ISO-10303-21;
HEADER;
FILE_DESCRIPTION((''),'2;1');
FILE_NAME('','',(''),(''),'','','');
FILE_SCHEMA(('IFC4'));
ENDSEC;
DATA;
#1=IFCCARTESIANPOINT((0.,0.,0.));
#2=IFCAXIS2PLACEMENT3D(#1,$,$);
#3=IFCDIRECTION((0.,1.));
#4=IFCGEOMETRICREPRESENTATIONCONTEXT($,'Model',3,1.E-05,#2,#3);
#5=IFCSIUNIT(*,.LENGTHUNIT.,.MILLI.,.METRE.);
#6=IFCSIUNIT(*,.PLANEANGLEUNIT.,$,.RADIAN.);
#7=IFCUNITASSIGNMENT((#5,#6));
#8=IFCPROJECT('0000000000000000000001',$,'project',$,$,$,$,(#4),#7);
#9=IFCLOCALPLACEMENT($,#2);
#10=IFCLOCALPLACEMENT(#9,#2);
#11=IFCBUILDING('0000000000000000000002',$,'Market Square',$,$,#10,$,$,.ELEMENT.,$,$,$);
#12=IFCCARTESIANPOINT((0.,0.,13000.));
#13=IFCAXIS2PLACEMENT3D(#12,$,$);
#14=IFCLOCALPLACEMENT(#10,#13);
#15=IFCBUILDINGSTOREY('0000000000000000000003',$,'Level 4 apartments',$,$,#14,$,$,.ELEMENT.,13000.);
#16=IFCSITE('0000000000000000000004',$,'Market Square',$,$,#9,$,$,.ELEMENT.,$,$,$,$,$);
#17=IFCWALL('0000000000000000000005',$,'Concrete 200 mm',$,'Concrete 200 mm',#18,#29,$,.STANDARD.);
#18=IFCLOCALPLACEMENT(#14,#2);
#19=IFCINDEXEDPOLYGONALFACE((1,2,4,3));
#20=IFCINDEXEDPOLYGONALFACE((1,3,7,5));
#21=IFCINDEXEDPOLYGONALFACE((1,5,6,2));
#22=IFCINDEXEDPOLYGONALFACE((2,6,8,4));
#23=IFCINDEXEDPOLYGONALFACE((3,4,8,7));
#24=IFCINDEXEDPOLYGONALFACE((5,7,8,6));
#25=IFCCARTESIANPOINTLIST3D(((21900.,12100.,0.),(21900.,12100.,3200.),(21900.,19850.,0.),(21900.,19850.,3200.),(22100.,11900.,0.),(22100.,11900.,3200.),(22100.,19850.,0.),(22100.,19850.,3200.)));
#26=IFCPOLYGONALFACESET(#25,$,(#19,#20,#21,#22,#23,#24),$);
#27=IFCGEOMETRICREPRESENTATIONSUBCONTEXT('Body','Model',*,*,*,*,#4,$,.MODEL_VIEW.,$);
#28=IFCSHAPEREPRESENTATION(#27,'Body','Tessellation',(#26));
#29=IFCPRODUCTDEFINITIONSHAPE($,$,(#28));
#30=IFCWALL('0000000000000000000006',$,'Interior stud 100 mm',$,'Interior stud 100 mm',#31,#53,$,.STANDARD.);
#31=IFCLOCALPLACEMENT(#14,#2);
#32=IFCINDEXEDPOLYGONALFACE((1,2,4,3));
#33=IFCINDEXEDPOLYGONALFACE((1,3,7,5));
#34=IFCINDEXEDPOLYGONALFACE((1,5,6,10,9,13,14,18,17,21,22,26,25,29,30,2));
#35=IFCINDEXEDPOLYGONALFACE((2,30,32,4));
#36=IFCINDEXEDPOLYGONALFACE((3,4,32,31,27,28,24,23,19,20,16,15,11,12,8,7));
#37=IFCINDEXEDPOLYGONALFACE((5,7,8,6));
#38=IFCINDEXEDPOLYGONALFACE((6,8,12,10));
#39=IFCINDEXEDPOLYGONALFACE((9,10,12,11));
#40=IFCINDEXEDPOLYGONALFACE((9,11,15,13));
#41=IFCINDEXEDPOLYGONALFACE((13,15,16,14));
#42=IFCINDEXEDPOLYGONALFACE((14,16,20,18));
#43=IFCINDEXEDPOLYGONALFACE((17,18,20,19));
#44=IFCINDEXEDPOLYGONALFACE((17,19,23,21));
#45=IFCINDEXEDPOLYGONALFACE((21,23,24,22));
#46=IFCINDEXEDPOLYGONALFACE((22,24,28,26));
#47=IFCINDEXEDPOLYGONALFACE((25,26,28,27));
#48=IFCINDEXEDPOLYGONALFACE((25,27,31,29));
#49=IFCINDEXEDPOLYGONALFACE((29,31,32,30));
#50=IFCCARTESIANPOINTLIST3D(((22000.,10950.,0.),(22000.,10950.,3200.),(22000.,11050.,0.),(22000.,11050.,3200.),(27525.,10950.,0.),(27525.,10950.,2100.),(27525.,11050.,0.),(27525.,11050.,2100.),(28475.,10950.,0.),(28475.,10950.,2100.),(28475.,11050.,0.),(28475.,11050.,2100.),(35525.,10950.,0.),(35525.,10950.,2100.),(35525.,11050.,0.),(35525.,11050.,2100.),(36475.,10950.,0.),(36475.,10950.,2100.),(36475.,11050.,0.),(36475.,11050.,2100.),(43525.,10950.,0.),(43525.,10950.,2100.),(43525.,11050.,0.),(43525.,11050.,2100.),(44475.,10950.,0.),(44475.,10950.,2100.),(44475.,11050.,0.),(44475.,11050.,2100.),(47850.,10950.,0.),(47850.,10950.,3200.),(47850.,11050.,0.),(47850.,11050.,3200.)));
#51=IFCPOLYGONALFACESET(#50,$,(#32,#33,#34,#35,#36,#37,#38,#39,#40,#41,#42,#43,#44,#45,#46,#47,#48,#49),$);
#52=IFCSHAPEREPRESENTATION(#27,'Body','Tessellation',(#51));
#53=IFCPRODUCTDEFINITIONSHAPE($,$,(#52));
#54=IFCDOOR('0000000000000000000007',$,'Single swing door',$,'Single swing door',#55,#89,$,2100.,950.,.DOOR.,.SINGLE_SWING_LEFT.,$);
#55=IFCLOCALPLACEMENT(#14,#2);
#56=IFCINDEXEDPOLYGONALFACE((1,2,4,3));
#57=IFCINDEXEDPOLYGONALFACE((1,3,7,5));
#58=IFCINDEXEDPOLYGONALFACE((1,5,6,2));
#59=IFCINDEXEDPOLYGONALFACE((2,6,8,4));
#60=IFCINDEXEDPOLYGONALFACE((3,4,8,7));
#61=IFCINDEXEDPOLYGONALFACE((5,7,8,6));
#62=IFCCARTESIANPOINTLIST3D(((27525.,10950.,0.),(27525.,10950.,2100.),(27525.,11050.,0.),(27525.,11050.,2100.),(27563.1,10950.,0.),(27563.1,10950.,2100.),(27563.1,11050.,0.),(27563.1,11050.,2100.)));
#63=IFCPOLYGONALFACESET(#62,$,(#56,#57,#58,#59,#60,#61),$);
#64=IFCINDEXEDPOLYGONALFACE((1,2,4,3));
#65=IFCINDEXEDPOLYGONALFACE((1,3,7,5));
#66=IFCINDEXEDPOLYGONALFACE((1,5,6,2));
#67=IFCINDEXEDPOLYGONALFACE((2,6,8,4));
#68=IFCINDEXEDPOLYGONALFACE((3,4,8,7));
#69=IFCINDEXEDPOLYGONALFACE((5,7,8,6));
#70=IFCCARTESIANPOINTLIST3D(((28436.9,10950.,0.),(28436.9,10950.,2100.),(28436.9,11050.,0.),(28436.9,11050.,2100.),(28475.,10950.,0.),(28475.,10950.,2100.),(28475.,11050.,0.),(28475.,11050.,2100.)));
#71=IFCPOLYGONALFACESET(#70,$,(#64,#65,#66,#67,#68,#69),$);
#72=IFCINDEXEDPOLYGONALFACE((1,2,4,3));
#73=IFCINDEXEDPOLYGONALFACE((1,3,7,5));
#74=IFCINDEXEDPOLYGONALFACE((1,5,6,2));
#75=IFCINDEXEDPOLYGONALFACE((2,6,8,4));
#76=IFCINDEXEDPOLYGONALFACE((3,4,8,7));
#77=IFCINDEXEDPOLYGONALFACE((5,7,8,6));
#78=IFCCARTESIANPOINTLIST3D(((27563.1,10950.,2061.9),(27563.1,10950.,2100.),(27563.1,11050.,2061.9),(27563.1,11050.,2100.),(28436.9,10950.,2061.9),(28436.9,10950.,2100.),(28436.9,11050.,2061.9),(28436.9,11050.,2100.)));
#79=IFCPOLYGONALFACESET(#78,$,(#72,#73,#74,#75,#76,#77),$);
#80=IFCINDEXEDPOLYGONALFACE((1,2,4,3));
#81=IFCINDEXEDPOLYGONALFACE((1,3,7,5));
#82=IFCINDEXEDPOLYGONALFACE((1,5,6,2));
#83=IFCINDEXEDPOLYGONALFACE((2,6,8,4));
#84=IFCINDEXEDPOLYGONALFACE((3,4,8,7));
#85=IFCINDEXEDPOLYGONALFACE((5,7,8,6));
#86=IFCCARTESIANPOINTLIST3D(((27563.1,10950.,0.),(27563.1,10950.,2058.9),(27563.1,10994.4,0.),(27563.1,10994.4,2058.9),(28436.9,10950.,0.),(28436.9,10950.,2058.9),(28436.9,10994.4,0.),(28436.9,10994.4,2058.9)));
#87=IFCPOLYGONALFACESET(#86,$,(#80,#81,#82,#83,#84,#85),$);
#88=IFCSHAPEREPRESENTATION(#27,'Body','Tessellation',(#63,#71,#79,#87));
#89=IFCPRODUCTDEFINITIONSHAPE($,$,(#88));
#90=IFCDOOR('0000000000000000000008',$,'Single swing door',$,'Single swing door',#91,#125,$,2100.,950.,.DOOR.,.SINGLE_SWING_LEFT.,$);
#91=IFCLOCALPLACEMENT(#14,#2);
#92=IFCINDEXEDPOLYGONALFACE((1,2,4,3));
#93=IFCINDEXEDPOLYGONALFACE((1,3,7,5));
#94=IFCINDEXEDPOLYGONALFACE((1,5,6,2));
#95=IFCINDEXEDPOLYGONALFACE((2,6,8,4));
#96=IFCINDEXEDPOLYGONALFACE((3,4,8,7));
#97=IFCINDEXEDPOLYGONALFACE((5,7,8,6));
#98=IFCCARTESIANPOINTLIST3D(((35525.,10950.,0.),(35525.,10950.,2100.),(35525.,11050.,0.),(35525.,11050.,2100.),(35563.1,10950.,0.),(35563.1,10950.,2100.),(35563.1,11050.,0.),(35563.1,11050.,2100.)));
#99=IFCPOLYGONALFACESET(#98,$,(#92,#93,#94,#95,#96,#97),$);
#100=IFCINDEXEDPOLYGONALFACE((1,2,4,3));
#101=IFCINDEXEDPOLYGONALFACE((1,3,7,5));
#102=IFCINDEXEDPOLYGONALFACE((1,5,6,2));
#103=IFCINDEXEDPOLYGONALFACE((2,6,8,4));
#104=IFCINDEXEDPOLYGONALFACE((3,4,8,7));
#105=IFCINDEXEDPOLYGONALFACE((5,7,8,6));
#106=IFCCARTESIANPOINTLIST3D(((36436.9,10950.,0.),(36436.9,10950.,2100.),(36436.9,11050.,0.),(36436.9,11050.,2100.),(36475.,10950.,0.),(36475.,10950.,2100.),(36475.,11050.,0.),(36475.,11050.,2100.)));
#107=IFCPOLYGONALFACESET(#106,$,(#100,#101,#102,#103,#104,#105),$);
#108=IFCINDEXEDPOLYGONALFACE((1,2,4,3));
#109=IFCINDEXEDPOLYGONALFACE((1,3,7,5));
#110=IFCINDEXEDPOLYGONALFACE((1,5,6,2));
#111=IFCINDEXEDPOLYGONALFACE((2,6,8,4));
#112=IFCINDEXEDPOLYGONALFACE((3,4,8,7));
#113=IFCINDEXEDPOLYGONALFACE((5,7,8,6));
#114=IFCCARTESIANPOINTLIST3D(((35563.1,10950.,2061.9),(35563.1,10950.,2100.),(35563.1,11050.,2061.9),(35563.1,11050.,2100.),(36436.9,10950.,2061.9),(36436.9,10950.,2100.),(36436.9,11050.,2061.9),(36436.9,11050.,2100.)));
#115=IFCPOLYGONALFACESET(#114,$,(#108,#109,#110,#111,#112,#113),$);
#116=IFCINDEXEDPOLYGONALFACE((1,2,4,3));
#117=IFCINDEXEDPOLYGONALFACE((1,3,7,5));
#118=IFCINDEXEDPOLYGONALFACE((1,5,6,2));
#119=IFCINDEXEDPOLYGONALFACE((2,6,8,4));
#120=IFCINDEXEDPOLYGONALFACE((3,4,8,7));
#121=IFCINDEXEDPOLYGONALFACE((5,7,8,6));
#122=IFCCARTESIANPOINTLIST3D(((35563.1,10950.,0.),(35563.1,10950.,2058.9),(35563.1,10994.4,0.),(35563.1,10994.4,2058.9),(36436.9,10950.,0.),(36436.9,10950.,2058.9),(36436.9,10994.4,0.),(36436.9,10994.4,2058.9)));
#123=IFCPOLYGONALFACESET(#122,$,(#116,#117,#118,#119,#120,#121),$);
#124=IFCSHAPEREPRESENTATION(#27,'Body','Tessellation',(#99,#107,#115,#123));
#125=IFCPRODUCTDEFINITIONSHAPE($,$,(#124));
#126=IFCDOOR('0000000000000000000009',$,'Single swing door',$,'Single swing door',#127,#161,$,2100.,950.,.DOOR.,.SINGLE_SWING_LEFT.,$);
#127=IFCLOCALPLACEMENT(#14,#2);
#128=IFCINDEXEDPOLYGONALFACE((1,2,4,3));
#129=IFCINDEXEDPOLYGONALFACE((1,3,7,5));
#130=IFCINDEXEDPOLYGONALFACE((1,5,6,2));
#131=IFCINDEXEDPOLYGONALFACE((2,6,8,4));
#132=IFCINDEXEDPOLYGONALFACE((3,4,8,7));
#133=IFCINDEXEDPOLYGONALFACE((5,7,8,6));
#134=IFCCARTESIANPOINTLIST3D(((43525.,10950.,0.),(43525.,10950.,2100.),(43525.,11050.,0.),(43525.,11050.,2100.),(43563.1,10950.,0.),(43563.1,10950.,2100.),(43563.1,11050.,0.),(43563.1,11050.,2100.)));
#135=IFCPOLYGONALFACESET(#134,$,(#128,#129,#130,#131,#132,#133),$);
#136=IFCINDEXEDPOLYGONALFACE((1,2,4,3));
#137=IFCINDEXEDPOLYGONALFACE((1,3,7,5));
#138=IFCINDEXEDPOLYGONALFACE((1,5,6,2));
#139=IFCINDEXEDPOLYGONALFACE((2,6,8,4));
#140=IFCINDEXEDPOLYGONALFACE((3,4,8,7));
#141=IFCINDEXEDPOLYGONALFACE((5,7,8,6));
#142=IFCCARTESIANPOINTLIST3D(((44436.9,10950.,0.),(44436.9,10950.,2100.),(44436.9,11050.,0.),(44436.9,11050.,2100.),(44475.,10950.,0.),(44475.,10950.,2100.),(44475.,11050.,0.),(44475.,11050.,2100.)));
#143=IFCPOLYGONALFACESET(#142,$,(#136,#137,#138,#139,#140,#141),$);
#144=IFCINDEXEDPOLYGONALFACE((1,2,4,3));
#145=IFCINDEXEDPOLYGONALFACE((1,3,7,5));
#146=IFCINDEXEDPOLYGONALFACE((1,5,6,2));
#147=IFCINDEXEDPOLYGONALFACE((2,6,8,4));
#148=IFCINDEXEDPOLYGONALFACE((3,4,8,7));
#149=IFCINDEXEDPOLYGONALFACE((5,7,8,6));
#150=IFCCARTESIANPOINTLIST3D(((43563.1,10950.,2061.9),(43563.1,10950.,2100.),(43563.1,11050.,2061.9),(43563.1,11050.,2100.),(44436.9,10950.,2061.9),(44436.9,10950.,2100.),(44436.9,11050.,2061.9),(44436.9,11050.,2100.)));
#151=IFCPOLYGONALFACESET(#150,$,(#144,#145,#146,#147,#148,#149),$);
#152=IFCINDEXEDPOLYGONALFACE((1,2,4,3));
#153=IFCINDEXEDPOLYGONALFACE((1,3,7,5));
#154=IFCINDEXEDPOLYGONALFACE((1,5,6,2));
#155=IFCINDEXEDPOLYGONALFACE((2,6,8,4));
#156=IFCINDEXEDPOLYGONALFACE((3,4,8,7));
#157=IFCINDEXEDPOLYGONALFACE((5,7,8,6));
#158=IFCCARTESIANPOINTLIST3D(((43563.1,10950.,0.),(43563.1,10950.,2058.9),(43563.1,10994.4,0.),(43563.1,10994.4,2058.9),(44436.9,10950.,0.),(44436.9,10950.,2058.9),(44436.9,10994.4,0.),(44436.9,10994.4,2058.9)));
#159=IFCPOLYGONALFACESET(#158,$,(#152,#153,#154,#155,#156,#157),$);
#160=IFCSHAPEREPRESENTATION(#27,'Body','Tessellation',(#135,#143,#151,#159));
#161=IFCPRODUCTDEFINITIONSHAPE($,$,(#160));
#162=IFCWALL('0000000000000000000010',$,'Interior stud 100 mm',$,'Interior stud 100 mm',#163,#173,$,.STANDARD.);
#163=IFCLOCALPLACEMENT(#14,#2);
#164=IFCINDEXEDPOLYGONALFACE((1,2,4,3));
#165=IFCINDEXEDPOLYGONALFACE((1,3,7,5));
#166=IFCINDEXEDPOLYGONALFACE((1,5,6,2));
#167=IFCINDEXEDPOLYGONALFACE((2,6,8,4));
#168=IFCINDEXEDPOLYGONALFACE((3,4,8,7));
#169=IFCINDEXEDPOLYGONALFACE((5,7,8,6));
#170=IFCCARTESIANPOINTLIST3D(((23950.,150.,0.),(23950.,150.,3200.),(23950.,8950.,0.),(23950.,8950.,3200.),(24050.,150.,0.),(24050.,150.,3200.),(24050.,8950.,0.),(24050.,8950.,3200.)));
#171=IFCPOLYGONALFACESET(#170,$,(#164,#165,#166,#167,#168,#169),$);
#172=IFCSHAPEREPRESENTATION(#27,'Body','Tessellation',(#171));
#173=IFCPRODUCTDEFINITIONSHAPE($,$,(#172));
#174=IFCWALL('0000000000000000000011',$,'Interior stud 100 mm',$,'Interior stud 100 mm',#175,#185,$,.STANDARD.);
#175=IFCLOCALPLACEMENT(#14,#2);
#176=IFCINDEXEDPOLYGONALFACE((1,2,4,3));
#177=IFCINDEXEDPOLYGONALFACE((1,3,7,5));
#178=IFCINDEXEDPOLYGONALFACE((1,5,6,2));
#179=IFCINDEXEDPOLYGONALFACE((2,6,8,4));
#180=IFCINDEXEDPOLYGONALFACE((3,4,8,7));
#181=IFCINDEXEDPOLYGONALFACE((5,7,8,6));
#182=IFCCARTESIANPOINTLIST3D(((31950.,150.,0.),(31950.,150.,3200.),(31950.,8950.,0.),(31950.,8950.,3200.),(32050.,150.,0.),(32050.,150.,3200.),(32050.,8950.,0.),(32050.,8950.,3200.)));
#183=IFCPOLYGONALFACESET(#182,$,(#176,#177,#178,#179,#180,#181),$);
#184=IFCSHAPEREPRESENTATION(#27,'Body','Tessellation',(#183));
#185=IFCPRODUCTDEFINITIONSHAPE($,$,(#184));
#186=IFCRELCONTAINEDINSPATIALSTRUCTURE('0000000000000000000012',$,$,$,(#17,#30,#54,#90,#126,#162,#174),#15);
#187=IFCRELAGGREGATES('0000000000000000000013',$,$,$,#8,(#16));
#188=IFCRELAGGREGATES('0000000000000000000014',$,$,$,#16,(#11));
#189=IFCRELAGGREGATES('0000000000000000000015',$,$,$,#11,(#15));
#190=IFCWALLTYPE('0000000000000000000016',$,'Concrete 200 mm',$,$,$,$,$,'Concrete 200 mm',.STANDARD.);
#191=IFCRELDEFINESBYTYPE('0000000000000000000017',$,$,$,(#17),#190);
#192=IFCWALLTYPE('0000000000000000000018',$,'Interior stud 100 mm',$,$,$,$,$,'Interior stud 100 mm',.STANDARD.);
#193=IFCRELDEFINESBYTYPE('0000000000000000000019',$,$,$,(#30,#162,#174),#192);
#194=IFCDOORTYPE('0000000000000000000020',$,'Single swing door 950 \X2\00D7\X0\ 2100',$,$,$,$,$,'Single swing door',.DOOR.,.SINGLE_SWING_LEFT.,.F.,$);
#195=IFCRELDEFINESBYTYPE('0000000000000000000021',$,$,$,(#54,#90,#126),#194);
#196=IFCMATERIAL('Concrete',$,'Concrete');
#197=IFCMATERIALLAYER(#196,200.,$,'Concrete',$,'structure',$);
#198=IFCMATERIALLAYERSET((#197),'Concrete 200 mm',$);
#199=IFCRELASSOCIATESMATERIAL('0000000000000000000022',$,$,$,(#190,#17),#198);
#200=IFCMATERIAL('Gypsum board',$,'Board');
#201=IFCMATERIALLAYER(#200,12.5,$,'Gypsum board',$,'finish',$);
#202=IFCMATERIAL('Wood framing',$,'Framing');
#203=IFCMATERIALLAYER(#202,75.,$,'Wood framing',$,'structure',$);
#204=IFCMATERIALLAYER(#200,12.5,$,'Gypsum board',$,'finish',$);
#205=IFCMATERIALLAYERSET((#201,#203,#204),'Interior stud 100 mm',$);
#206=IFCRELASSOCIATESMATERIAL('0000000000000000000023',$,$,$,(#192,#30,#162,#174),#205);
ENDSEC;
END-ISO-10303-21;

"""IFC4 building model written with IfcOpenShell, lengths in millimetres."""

from ifc_helpers import new_model, si_unit, direction, frame, origin, origin_with_axes, place, context, subcontext, project, spatial, polyline, outline, extrude, material, layer, layer_set, layer_usage, type_object, element, fill, save


model = new_model("IFC4")

# Units and contexts
model_context = context("Model", 3, precision=1e-05, world=origin(), true_north=direction((0.0, 1.0)))
body_context = subcontext(model_context, "Body", "Model", "MODEL_VIEW")
ifc_project = project(units=[si_unit("LENGTHUNIT", "METRE", prefix="MILLI"), si_unit("PLANEANGLEUNIT", "RADIAN")], contexts=[model_context])

# Site, building, storey
site_placement = place(None, origin())
site = spatial("IfcSite", under=ifc_project, at=site_placement, Name="Market Square", CompositionType="ELEMENT")
building_placement = place(site_placement, origin())
building = spatial("IfcBuilding", under=site, at=building_placement, Name="Market Square", CompositionType="ELEMENT")
storey_placement = place(building_placement, frame((0.0, 0.0, 13000.0)))
storey = spatial("IfcBuildingStorey", under=building, at=storey_placement, Name="Level 4 apartments", CompositionType="ELEMENT", Elevation=13000.0)

# Wall
ifc_material_1 = material(Name="Concrete", Category="Concrete")
ifc_layer_1 = layer(ifc_material_1, 200.0, Name="Concrete", Category="structure")
ifc_layer_set_1 = layer_set([ifc_layer_1], Name="Concrete 200 mm")
ifc_layer_usage_1 = layer_usage(ifc_layer_set_1, "AXIS2", "NEGATIVE", 100.0)
wall_type_1 = type_object("IfcWallType", Name="Concrete 200 mm", ElementType="Concrete 200 mm", PredefinedType="STANDARD", material=ifc_layer_set_1)
wall_1_placement = place(storey_placement, frame((22000.0, 12000.0, 0.0), z_axis=(0.0, 0.0, 1.0), x_axis=(0.0, 1.0, 0.0)))
element("IfcWall", 1, at=wall_1_placement, inside=storey, type_object=wall_type_1, material=ifc_layer_usage_1, Name="Concrete 200 mm", ObjectType="Concrete 200 mm", PredefinedType="STANDARD", context=body_context, shape_type="SweptSolid", body=[
    extrude(outline(polyline([(-100.0, -100.0), (7850.0, -100.0), (7850.0, 100.0), (100.0, 100.0), (-100.0, -100.0)])), origin(), (0.0, 0.0, 1.0), 3200.0),
])

# Wall, openings, doors
ifc_material_2 = material(Name="Gypsum board", Category="Board")
ifc_layer_2 = layer(ifc_material_2, 12.5, Name="Gypsum board", Category="finish")
ifc_material_3 = material(Name="Wood framing", Category="Framing")
ifc_layer_3 = layer(ifc_material_3, 75.0, Name="Wood framing", Category="structure")
ifc_layer_4 = layer(ifc_material_2, 12.5, Name="Gypsum board", Category="finish")
ifc_layer_set_2 = layer_set([ifc_layer_2, ifc_layer_3, ifc_layer_4], Name="Interior stud 100 mm")
ifc_layer_usage_2 = layer_usage(ifc_layer_set_2, "AXIS2", "NEGATIVE", 50.0)
wall_type_2 = type_object("IfcWallType", Name="Interior stud 100 mm", ElementType="Interior stud 100 mm", PredefinedType="STANDARD", material=ifc_layer_set_2)
wall_2_placement = place(storey_placement, frame((22000.0, 11000.0, 0.0), z_axis=(0.0, 0.0, 1.0), x_axis=(1.0, 0.0, 0.0)))
wall_2 = element("IfcWall", 2, at=wall_2_placement, inside=storey, type_object=wall_type_2, material=ifc_layer_usage_2, Name="Interior stud 100 mm", ObjectType="Interior stud 100 mm", PredefinedType="STANDARD", context=body_context, shape_type="SweptSolid", body=[
    extrude(outline(polyline([(0.0, -50.0), (25850.0, -50.0), (25850.0, 50.0), (0.0, 50.0), (0.0, -50.0)])), origin(), (0.0, 0.0, 1.0), 3200.0),
])
opening_1_placement = place(wall_2_placement, frame((5525.0, 0.0, 0.0), z_axis=(0.0, 0.0, 1.0), x_axis=(1.0, 0.0, 0.0)))
opening_1 = element("IfcOpeningElement", 3, at=opening_1_placement, cuts=wall_2, PredefinedType="OPENING", context=body_context, shape_type="SweptSolid", body=[
    extrude(outline(polyline([(0.0, -60.0), (950.0, -60.0), (950.0, 60.0), (0.0, 60.0), (0.0, -60.0)])), origin(), (0.0, 0.0, 1.0), 2100.0),
])
opening_2_placement = place(wall_2_placement, frame((13525.0, 0.0, 0.0), z_axis=(0.0, 0.0, 1.0), x_axis=(1.0, 0.0, 0.0)))
opening_2 = element("IfcOpeningElement", 4, at=opening_2_placement, cuts=wall_2, PredefinedType="OPENING", context=body_context, shape_type="SweptSolid", body=[
    extrude(outline(polyline([(0.0, -60.0), (950.0, -60.0), (950.0, 60.0), (0.0, 60.0), (0.0, -60.0)])), origin(), (0.0, 0.0, 1.0), 2100.0),
])
opening_3_placement = place(wall_2_placement, frame((21525.0, 0.0, 0.0), z_axis=(0.0, 0.0, 1.0), x_axis=(1.0, 0.0, 0.0)))
opening_3 = element("IfcOpeningElement", 5, at=opening_3_placement, cuts=wall_2, PredefinedType="OPENING", context=body_context, shape_type="SweptSolid", body=[
    extrude(outline(polyline([(0.0, -60.0), (950.0, -60.0), (950.0, 60.0), (0.0, 60.0), (0.0, -60.0)])), origin(), (0.0, 0.0, 1.0), 2100.0),
])
door_type = type_object("IfcDoorType", Name="Single swing door 950 × 2100", ElementType="Single swing door", OperationType="SINGLE_SWING_LEFT", ParameterTakesPrecedence=False, PredefinedType="DOOR")
door_1_placement = place(opening_1_placement, origin_with_axes())
door_1 = element("IfcDoor", 6, at=door_1_placement, inside=storey, type_object=door_type, Name="Single swing door", ObjectType="Single swing door", OperationType="SINGLE_SWING_LEFT", OverallHeight=2100.0, OverallWidth=950.0, PredefinedType="DOOR", context=body_context, shape_type="SweptSolid", body=[
    extrude(outline(polyline([(0.0, -50.0), (38.1, -50.0), (38.1, 50.0), (0.0, 50.0), (0.0, -50.0)])), origin(), (0.0, 0.0, 1.0), 2100.0),
    extrude(outline(polyline([(911.9, -50.0), (950.0, -50.0), (950.0, 50.0), (911.9, 50.0), (911.9, -50.0)])), origin(), (0.0, 0.0, 1.0), 2100.0),
    extrude(outline(polyline([(38.1, -50.0), (911.9, -50.0), (911.9, 50.0), (38.1, 50.0), (38.1, -50.0)])), frame((0.0, 0.0, 2061.9)), (0.0, 0.0, 1.0), 38.1),
    extrude(outline(polyline([(38.1, -50.0), (911.9, -50.0), (911.9, -5.5), (38.1, -5.5), (38.1, -50.0)])), origin(), (0.0, 0.0, 1.0), 2058.9),
])
fill(opening_1, door_1)
door_2_placement = place(opening_2_placement, origin_with_axes())
door_2 = element("IfcDoor", 7, at=door_2_placement, inside=storey, type_object=door_type, Name="Single swing door", ObjectType="Single swing door", OperationType="SINGLE_SWING_LEFT", OverallHeight=2100.0, OverallWidth=950.0, PredefinedType="DOOR", context=body_context, shape_type="SweptSolid", body=[
    extrude(outline(polyline([(0.0, -50.0), (38.1, -50.0), (38.1, 50.0), (0.0, 50.0), (0.0, -50.0)])), origin(), (0.0, 0.0, 1.0), 2100.0),
    extrude(outline(polyline([(911.9, -50.0), (950.0, -50.0), (950.0, 50.0), (911.9, 50.0), (911.9, -50.0)])), origin(), (0.0, 0.0, 1.0), 2100.0),
    extrude(outline(polyline([(38.1, -50.0), (911.9, -50.0), (911.9, 50.0), (38.1, 50.0), (38.1, -50.0)])), frame((0.0, 0.0, 2061.9)), (0.0, 0.0, 1.0), 38.1),
    extrude(outline(polyline([(38.1, -50.0), (911.9, -50.0), (911.9, -5.5), (38.1, -5.5), (38.1, -50.0)])), origin(), (0.0, 0.0, 1.0), 2058.9),
])
fill(opening_2, door_2)
door_3_placement = place(opening_3_placement, origin_with_axes())
door_3 = element("IfcDoor", 8, at=door_3_placement, inside=storey, type_object=door_type, Name="Single swing door", ObjectType="Single swing door", OperationType="SINGLE_SWING_LEFT", OverallHeight=2100.0, OverallWidth=950.0, PredefinedType="DOOR", context=body_context, shape_type="SweptSolid", body=[
    extrude(outline(polyline([(0.0, -50.0), (38.1, -50.0), (38.1, 50.0), (0.0, 50.0), (0.0, -50.0)])), origin(), (0.0, 0.0, 1.0), 2100.0),
    extrude(outline(polyline([(911.9, -50.0), (950.0, -50.0), (950.0, 50.0), (911.9, 50.0), (911.9, -50.0)])), origin(), (0.0, 0.0, 1.0), 2100.0),
    extrude(outline(polyline([(38.1, -50.0), (911.9, -50.0), (911.9, 50.0), (38.1, 50.0), (38.1, -50.0)])), frame((0.0, 0.0, 2061.9)), (0.0, 0.0, 1.0), 38.1),
    extrude(outline(polyline([(38.1, -50.0), (911.9, -50.0), (911.9, -5.5), (38.1, -5.5), (38.1, -50.0)])), origin(), (0.0, 0.0, 1.0), 2058.9),
])
fill(opening_3, door_3)

# Walls
ifc_layer_usage_3 = layer_usage(ifc_layer_set_2, "AXIS2", "NEGATIVE", 50.0)
wall_3_placement = place(storey_placement, frame((24000.0, 0.0, 0.0), z_axis=(0.0, 0.0, 1.0), x_axis=(0.0, 1.0, 0.0)))
element("IfcWall", 9, at=wall_3_placement, inside=storey, type_object=wall_type_2, material=ifc_layer_usage_3, Name="Interior stud 100 mm", ObjectType="Interior stud 100 mm", PredefinedType="STANDARD", context=body_context, shape_type="SweptSolid", body=[
    extrude(outline(polyline([(150.0, -50.0), (8950.0, -50.0), (8950.0, 50.0), (150.0, 50.0), (150.0, -50.0)])), origin(), (0.0, 0.0, 1.0), 3200.0),
])
ifc_layer_usage_4 = layer_usage(ifc_layer_set_2, "AXIS2", "NEGATIVE", 50.0)
wall_4_placement = place(storey_placement, frame((32000.0, 0.0, 0.0), z_axis=(0.0, 0.0, 1.0), x_axis=(0.0, 1.0, 0.0)))
element("IfcWall", 10, at=wall_4_placement, inside=storey, type_object=wall_type_2, material=ifc_layer_usage_4, Name="Interior stud 100 mm", ObjectType="Interior stud 100 mm", PredefinedType="STANDARD", context=body_context, shape_type="SweptSolid", body=[
    extrude(outline(polyline([(150.0, -50.0), (8950.0, -50.0), (8950.0, 50.0), (150.0, 50.0), (150.0, -50.0)])), origin(), (0.0, 0.0, 1.0), 3200.0),
])

save(model, "model.ifc")
